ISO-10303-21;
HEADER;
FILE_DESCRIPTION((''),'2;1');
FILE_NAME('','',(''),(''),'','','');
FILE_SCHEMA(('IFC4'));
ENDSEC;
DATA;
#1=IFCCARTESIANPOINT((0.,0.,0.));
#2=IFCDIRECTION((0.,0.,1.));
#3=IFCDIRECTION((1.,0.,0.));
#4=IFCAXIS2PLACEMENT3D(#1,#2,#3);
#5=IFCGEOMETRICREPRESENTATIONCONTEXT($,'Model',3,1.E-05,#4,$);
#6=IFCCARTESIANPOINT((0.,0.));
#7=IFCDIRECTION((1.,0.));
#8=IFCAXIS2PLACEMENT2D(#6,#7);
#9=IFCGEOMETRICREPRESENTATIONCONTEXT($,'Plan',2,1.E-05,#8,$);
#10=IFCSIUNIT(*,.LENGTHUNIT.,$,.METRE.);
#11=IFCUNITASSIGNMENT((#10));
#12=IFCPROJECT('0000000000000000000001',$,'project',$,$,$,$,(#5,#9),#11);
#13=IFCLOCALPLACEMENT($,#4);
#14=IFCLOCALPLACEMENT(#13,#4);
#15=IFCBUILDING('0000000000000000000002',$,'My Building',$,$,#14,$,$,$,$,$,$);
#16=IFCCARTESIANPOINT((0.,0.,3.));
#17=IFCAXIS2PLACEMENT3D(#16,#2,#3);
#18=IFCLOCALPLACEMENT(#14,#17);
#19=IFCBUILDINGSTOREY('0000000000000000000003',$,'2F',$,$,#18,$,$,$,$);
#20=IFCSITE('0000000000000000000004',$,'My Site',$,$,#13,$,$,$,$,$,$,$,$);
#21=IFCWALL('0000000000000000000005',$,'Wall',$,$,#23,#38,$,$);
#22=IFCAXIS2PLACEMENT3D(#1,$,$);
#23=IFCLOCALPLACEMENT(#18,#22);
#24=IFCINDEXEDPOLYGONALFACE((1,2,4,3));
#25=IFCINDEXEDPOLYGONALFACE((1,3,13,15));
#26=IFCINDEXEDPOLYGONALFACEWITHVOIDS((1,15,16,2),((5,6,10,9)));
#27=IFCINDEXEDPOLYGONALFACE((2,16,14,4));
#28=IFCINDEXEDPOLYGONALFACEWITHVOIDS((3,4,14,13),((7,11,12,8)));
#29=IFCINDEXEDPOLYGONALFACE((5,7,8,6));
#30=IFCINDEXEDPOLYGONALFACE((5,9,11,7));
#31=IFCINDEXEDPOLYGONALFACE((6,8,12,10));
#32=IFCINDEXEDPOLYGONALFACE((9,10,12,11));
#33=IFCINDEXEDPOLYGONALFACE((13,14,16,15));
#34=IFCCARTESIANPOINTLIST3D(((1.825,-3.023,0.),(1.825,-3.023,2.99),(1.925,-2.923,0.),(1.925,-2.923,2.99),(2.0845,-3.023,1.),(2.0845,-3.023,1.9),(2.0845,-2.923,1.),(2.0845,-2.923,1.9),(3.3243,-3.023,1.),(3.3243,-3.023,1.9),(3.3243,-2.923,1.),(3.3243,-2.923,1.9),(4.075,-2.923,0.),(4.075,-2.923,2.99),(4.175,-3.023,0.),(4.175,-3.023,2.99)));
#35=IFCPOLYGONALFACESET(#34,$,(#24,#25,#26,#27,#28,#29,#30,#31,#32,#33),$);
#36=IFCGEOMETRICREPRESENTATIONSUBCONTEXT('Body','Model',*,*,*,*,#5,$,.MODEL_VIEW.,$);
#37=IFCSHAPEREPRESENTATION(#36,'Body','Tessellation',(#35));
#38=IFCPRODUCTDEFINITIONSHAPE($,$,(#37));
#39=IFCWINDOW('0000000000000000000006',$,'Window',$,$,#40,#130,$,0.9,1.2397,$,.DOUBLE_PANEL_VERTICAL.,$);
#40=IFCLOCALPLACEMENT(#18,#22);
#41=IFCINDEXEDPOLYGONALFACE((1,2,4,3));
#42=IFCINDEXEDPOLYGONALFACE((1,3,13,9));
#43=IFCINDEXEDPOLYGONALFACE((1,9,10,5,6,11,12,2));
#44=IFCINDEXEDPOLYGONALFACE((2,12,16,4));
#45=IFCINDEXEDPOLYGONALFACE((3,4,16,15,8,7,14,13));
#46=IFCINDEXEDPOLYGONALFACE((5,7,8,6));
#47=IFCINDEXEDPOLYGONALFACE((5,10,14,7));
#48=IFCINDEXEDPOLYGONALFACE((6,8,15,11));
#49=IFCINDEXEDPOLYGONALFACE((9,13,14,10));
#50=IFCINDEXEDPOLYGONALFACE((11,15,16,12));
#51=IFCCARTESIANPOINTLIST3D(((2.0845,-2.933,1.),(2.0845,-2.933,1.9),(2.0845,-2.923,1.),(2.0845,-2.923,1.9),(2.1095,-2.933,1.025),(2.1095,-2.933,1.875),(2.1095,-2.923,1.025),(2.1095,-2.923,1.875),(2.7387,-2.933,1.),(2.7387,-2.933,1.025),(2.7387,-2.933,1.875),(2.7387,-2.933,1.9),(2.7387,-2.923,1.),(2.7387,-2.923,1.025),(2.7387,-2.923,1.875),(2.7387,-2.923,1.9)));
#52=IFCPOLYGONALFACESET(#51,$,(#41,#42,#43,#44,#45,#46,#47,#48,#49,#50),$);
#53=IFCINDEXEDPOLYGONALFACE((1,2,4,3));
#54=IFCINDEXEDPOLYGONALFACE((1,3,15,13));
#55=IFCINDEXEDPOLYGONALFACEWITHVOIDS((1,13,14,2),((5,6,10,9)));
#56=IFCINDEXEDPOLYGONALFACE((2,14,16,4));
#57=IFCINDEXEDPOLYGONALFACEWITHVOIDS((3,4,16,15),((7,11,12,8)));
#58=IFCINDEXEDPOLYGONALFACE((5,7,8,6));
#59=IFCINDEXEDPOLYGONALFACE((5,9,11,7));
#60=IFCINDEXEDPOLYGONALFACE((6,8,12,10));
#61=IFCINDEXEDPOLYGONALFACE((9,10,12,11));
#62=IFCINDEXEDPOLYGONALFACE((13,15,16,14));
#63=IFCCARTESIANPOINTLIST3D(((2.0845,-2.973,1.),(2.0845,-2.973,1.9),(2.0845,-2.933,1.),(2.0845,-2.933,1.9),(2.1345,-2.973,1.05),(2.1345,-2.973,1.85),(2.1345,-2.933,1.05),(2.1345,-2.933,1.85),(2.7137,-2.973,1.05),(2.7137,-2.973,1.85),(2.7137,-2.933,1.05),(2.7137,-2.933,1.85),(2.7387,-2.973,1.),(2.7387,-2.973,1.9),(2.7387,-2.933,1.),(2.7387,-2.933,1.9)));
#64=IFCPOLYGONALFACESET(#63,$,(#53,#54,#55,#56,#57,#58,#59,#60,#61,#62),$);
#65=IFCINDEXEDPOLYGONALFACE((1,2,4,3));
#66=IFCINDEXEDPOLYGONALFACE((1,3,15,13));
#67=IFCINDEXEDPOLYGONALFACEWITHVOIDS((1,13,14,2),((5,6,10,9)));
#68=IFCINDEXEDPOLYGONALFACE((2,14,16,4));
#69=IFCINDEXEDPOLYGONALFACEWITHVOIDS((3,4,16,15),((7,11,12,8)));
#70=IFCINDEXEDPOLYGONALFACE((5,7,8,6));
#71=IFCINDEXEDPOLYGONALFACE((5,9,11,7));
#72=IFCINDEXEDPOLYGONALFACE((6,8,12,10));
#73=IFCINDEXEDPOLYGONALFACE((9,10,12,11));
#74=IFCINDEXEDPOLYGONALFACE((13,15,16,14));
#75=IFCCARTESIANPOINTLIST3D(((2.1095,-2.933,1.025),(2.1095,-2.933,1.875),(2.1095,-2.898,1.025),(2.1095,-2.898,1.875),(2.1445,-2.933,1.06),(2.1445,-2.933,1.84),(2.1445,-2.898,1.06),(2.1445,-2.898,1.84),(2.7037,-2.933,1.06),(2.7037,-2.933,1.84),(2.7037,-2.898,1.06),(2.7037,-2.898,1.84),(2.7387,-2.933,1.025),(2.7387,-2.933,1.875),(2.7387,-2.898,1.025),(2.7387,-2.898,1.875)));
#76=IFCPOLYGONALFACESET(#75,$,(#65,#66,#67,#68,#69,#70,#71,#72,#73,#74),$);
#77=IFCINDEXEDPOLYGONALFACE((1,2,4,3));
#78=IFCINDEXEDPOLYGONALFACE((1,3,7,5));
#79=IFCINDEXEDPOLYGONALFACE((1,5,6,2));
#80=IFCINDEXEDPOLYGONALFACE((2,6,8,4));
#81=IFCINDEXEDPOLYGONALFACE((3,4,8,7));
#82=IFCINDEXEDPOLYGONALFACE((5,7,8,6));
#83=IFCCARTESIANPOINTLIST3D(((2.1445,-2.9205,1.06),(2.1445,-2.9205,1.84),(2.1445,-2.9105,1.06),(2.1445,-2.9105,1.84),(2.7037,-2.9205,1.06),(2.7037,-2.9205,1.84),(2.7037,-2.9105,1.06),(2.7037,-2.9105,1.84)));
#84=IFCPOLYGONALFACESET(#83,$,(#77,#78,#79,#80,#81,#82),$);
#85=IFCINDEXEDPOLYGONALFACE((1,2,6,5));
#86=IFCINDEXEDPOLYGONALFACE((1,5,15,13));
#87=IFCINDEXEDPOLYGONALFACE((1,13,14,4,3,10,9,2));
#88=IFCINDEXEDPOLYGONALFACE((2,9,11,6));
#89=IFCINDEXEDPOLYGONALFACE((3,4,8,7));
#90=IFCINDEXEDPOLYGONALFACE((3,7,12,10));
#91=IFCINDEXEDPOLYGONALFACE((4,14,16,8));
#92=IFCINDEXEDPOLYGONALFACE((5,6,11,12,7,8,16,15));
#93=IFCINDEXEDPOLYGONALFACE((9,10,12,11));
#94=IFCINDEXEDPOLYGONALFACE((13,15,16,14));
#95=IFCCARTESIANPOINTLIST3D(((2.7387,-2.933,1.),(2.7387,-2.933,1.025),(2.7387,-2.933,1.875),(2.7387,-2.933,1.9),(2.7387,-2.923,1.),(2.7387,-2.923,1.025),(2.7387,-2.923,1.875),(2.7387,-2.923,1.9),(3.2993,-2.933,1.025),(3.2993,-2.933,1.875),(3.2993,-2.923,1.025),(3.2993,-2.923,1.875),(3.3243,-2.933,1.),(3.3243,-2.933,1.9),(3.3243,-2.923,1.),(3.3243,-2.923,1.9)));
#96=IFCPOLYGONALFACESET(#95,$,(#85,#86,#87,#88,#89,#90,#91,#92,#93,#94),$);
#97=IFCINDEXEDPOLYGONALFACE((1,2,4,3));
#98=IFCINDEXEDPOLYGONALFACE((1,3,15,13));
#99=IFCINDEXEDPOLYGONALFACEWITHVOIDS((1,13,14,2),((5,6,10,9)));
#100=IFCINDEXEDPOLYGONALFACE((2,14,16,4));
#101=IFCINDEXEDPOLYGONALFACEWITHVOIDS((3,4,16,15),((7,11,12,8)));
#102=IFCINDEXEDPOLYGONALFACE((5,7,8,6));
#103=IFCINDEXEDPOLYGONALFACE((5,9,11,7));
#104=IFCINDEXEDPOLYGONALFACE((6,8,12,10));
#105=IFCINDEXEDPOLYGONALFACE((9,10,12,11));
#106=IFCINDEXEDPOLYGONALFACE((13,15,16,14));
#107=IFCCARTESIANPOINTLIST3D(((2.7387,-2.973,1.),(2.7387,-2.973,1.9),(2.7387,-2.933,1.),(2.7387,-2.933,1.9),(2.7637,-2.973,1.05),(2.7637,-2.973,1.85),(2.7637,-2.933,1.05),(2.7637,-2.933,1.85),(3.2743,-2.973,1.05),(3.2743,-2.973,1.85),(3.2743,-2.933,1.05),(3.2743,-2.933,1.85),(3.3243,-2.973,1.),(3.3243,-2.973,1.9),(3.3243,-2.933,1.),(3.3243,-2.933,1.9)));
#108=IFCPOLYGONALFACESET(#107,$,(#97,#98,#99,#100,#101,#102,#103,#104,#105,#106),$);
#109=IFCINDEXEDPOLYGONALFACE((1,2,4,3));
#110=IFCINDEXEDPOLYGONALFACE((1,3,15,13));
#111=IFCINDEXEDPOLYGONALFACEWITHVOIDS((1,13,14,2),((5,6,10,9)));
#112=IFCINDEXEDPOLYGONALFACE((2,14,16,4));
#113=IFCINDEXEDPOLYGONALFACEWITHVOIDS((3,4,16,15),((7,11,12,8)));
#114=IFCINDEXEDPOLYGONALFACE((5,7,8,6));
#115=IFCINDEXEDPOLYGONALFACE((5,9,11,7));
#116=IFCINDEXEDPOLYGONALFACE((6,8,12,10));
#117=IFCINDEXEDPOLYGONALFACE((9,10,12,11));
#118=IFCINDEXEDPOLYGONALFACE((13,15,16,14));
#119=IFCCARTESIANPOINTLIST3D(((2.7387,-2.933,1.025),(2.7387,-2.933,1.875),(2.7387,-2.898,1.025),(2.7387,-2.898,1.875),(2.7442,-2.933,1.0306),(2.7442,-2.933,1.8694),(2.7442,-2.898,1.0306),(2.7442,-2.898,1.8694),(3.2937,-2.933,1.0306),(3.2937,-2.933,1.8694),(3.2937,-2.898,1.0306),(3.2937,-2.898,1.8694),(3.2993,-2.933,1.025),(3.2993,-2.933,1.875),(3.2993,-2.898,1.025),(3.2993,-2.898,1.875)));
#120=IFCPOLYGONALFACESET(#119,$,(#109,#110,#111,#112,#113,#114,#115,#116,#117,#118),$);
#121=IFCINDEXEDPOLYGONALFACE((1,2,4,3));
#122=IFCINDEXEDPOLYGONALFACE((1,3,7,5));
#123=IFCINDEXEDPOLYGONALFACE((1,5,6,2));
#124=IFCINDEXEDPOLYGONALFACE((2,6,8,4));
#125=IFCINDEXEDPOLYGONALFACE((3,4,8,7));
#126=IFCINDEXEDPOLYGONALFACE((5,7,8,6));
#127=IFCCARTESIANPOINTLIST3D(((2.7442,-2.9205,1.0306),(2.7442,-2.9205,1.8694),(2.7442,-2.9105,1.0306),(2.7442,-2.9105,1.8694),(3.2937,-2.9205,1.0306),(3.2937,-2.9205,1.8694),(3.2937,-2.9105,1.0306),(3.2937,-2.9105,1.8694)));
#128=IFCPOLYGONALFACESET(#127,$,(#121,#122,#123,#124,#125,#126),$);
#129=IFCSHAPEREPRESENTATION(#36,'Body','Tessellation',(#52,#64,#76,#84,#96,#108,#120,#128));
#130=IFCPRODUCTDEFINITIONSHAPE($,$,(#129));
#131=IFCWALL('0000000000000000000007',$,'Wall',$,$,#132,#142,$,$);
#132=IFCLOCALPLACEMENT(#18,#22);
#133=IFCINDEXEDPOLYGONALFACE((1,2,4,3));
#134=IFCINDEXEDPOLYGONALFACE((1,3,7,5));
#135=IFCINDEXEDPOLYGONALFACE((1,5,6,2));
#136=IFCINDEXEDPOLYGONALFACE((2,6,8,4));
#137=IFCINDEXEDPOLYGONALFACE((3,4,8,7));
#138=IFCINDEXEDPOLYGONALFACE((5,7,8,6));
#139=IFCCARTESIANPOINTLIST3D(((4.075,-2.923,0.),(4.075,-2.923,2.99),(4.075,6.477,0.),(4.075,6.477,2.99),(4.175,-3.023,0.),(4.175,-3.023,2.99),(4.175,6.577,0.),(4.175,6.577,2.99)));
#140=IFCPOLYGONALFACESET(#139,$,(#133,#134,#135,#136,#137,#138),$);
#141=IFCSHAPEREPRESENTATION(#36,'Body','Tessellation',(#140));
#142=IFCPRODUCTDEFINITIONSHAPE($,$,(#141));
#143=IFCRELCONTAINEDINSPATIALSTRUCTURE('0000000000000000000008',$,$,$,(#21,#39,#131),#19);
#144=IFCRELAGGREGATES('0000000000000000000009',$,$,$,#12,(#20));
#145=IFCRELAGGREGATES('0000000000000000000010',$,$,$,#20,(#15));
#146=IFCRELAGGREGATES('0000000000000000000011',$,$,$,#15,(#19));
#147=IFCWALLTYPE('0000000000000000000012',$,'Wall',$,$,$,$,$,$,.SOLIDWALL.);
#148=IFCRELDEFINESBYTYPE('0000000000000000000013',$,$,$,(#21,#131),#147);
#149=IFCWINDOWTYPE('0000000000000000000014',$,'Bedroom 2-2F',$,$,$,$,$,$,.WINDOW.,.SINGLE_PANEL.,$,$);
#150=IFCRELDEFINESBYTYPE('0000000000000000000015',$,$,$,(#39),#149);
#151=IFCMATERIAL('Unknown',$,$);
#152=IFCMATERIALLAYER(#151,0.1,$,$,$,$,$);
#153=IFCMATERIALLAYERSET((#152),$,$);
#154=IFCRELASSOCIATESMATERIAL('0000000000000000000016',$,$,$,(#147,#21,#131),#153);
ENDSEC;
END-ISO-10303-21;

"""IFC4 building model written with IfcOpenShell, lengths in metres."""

from ifc_helpers import new_model, entity, si_unit, frame, origin_with_axes, origin_2d_with_axis, place, context, subcontext, project, spatial, line, indexed_curve, outline, extrude, shape, source, transform, mapped, material, layer, layer_set, layer_usage, type_object, type_shapes, element, fill, save


model = new_model("IFC4")

# Units and contexts
model_context = context("Model", 3, precision=1e-05, world=origin_with_axes())
plan_context = context("Plan", 2, precision=1e-05, world=origin_2d_with_axis())
body_context_1 = subcontext(model_context, "Body", "Model", "MODEL_VIEW")
body_context_2 = subcontext(plan_context, "Body", "Plan", "PLAN_VIEW")
ifc_project = project(units=[si_unit("LENGTHUNIT", "METRE")], contexts=[model_context, plan_context])

# Site, building, storey
site_placement = place(None, origin_with_axes())
site = spatial("IfcSite", under=ifc_project, at=site_placement, Name="My Site")
building_placement = place(site_placement, origin_with_axes())
building = spatial("IfcBuilding", under=site, at=building_placement, Name="My Building")
storey_placement = place(building_placement, frame((0.0, 0.0, 3.0), z_axis=(0.0, 0.0, 1.0), x_axis=(1.0, 0.0, 0.0)))
storey = spatial("IfcBuildingStorey", under=building, at=storey_placement, Name="2F")

# Shared definitions
ifc_material = material(Name="Unknown")

# Shared definitions
ifc_layer_1 = layer(ifc_material, 0.1)
ifc_layer_set_1 = layer_set([ifc_layer_1])
wall_type = type_object("IfcWallType", Name="Wall", PredefinedType="SOLIDWALL", material=ifc_layer_set_1)

# Wall, opening, window
ifc_layer_usage_1 = layer_usage(ifc_layer_set_1, "AXIS2", "POSITIVE", 0.0)
wall_1_placement = place(storey_placement, frame((1.825, -3.023, 0.0), z_axis=(0.0, 0.0, 1.0), x_axis=(1.0, 0.0, 0.0)))
wall_1 = element("IfcWall", 1, at=wall_1_placement, inside=storey, type_object=wall_type, material=ifc_layer_usage_1, Name="Wall", context=body_context_1, shape_type="SweptSolid", body=[
    extrude(outline(indexed_curve([(0.0, 0.0), (0.1, 0.1), (2.25, 0.1), (2.35, 0.0)], segments=[line(1, 2, 3, 4, 1)])), origin_with_axes(), (0.0, 0.0, 1.0), 2.99),
])
shared_shape_1 = source(origin_with_axes(), body_context_1, "Body", "SweptSolid", [
    extrude(outline(indexed_curve([(0.0, 0.0), (1.2397, 0.0), (1.2397, 0.9), (0.0, 0.9)], segments=[line(1, 2, 3, 4, 1)])), frame((0.0, -0.6, 0.0), z_axis=(0.0, -1.0, 0.0), x_axis=(1.0, 0.0, 0.0)), (0.0, 0.0, -1.0), 1.2),
])
opening_1_placement = place(wall_1_placement, frame((0.2595, 0.0, 1.0), z_axis=(0.0, 0.0, 1.0), x_axis=(1.0, 0.0, 0.0)))
opening_1 = element("IfcOpeningElement", 2, at=opening_1_placement, cuts=wall_1, PredefinedType="OPENING", context=body_context_1, shape_type="MappedRepresentation", body=[
    mapped(shared_shape_1, transform((0.0, 0.0, 0.0), x_axis=(1.0, 0.0, 0.0), y_axis=(0.0, 1.0, 0.0), z_axis=(0.0, 0.0, 1.0), scale=1.0)),
])
window_type_1 = type_object("IfcWindowType", Name="Bedroom 2-2F", PartitioningType="SINGLE_PANEL", PredefinedType="WINDOW")
shared_shape_2 = source(origin_with_axes(), body_context_1, "Body", "SweptSolid", [
    extrude(outline(indexed_curve([(0.6541, 0.0), (0.0, 0.0), (0.0, 0.9), (0.6541, 0.9), (0.6541, 0.875), (0.025, 0.875), (0.025, 0.025), (0.6541, 0.025)], segments=[line(1, 2, 3, 4, 5, 6, 7, 8, 1)])), frame((0.0, 0.09, 0.0), z_axis=(0.0, -1.0, 0.0), x_axis=(1.0, 0.0, 0.0)), (0.0, 0.0, -1.0), 0.01),
    extrude(outline(indexed_curve([(0.0, 0.0), (0.6541, 0.0), (0.6541, 0.9), (0.0, 0.9)], segments=[line(1, 2, 3, 4, 1)]), holes=[indexed_curve([(0.05, 0.05), (0.6291, 0.05), (0.6291, 0.85), (0.05, 0.85)], segments=[line(1, 2, 3, 4, 1)])]), frame((0.0, 0.05, 0.0), z_axis=(0.0, -1.0, 0.0), x_axis=(1.0, 0.0, 0.0)), (0.0, 0.0, -1.0), 0.04),
    extrude(outline(indexed_curve([(0.0, 0.0), (0.6291, 0.0), (0.6291, 0.85), (0.0, 0.85)], segments=[line(1, 2, 3, 4, 1)]), holes=[indexed_curve([(0.035, 0.035), (0.5941, 0.035), (0.5941, 0.815), (0.035, 0.815)], segments=[line(1, 2, 3, 4, 1)])]), frame((0.025, 0.09, 0.025), z_axis=(0.0, -1.0, 0.0), x_axis=(1.0, 0.0, 0.0)), (0.0, 0.0, -1.0), 0.035),
    extrude(outline(indexed_curve([(0.035, 0.035), (0.5941, 0.035), (0.5941, 0.815), (0.035, 0.815)], segments=[line(1, 2, 3, 4, 1)])), frame((0.025, 0.1025, 0.025), z_axis=(0.0, -1.0, 0.0), x_axis=(1.0, 0.0, 0.0)), (0.0, 0.0, -1.0), 0.01),
    extrude(outline(indexed_curve([(0.0, 0.9), (0.5856, 0.9), (0.5856, 0.0), (0.0, 0.0), (0.0, 0.025), (0.5606, 0.025), (0.5606, 0.875), (0.0, 0.875)], segments=[line(1, 2, 3, 4, 5, 6, 7, 8, 1)])), frame((0.6541, 0.09, 0.0), z_axis=(0.0, -1.0, 0.0), x_axis=(1.0, 0.0, 0.0)), (0.0, 0.0, -1.0), 0.01),
    extrude(outline(indexed_curve([(0.0, 0.0), (0.5856, 0.0), (0.5856, 0.9), (0.0, 0.9)], segments=[line(1, 2, 3, 4, 1)]), holes=[indexed_curve([(0.025, 0.05), (0.5356, 0.05), (0.5356, 0.85), (0.025, 0.85)], segments=[line(1, 2, 3, 4, 1)])]), frame((0.6541, 0.05, 0.0), z_axis=(0.0, -1.0, 0.0), x_axis=(1.0, 0.0, 0.0)), (0.0, 0.0, -1.0), 0.04),
    extrude(outline(indexed_curve([(0.0, 0.0), (0.5606, 0.0), (0.5606, 0.85), (0.0, 0.85)], segments=[line(1, 2, 3, 4, 1)]), holes=[indexed_curve([(0.0056, 0.0056), (0.555, 0.0056), (0.555, 0.8444), (0.0056, 0.8444)], segments=[line(1, 2, 3, 4, 1)])]), frame((0.6541, 0.09, 0.025), z_axis=(0.0, -1.0, 0.0), x_axis=(1.0, 0.0, 0.0)), (0.0, 0.0, -1.0), 0.035),
    extrude(outline(indexed_curve([(0.0056, 0.0056), (0.555, 0.0056), (0.555, 0.8444), (0.0056, 0.8444)], segments=[line(1, 2, 3, 4, 1)])), frame((0.6541, 0.1025, 0.025), z_axis=(0.0, -1.0, 0.0), x_axis=(1.0, 0.0, 0.0)), (0.0, 0.0, -1.0), 0.01),
])
shared_shape_3 = source(origin_with_axes(), body_context_2, "Body", "Curve2D", [
    entity("IfcIndexedPolyCurve", entity("IfcCartesianPointList2D", [[0.05, 0.05], [0.6291, 0.05]])),
    entity("IfcIndexedPolyCurve", entity("IfcCartesianPointList2D", [[0.0, 0.1], [0.025, 0.1], [0.025, 0.09], [0.05, 0.09], [0.05, 0.05], [0.0, 0.05]]), [entity("IfcLineIndex", [1, 2, 3, 4, 5, 6, 1])]),
    entity("IfcIndexedPolyCurve", entity("IfcCartesianPointList2D", [[0.6541, 0.1], [0.6541, 0.1], [0.6541, 0.09], [0.6291, 0.09], [0.6291, 0.05], [0.6541, 0.05]])),
    entity("IfcIndexedPolyCurve", entity("IfcCartesianPointList2D", [[0.025, 0.09], [0.06, 0.09], [0.06, 0.125], [0.025, 0.125]]), [entity("IfcLineIndex", [1, 2, 3, 4, 1])]),
    entity("IfcIndexedPolyCurve", entity("IfcCartesianPointList2D", [[0.6541, 0.09], [0.6191, 0.09], [0.6191, 0.125], [0.6541, 0.125]]), [entity("IfcLineIndex", [1, 2, 3, 4, 1])]),
    entity("IfcIndexedPolyCurve", entity("IfcCartesianPointList2D", [[0.06, 0.09], [0.6191, 0.09]])),
    entity("IfcIndexedPolyCurve", entity("IfcCartesianPointList2D", [[0.06, 0.125], [0.6191, 0.125]])),
    entity("IfcIndexedPolyCurve", entity("IfcCartesianPointList2D", [[0.06, 0.1075], [0.6191, 0.1075]])),
    entity("IfcIndexedPolyCurve", entity("IfcCartesianPointList2D", [[0.6791, 0.05], [1.1897, 0.05]])),
    entity("IfcIndexedPolyCurve", entity("IfcCartesianPointList2D", [[0.6541, 0.1], [0.6541, 0.1], [0.6541, 0.09], [0.6791, 0.09], [0.6791, 0.05], [0.6541, 0.05]])),
    entity("IfcIndexedPolyCurve", entity("IfcCartesianPointList2D", [[1.2397, 0.1], [1.2147, 0.1], [1.2147, 0.09], [1.1897, 0.09], [1.1897, 0.05], [1.2397, 0.05]]), [entity("IfcLineIndex", [1, 2, 3, 4, 5, 6, 1])]),
    entity("IfcIndexedPolyCurve", entity("IfcCartesianPointList2D", [[0.6541, 0.09], [0.6597, 0.09], [0.6597, 0.125], [0.6541, 0.125]]), [entity("IfcLineIndex", [1, 2, 3, 4, 1])]),
    entity("IfcIndexedPolyCurve", entity("IfcCartesianPointList2D", [[1.2147, 0.09], [1.2092, 0.09], [1.2092, 0.125], [1.2147, 0.125]]), [entity("IfcLineIndex", [1, 2, 3, 4, 1])]),
    entity("IfcIndexedPolyCurve", entity("IfcCartesianPointList2D", [[0.6597, 0.09], [1.2092, 0.09]])),
    entity("IfcIndexedPolyCurve", entity("IfcCartesianPointList2D", [[0.6597, 0.125], [1.2092, 0.125]])),
    entity("IfcIndexedPolyCurve", entity("IfcCartesianPointList2D", [[0.6597, 0.1075], [1.2092, 0.1075]])),
])
type_shapes(window_type_1, [shared_shape_2, shared_shape_3])
window_1_placement = place(opening_1_placement, frame((0.0, 0.0, 0.0), z_axis=(0.0, 0.0, 1.0), x_axis=(1.0, 0.0, 0.0)))
window_1 = element("IfcWindow", 3, at=window_1_placement, inside=storey, type_object=window_type_1, Name="Window", OverallHeight=0.9, OverallWidth=1.2397, PartitioningType="DOUBLE_PANEL_VERTICAL", shapes=[
    shape(body_context_1, "Body", "MappedRepresentation", [mapped(shared_shape_2, transform((0.0, 0.0, 0.0), x_axis=(1.0, 0.0, 0.0), y_axis=(0.0, 1.0, 0.0), z_axis=(0.0, 0.0, 1.0), scale=1.0))]),
    shape(body_context_2, "Body", "MappedRepresentation", [mapped(shared_shape_3, transform((0.0, 0.0, 0.0), x_axis=(1.0, 0.0, 0.0), y_axis=(0.0, 1.0, 0.0), z_axis=(0.0, 0.0, 1.0), scale=1.0))]),
])
fill(opening_1, window_1)

# Wall
ifc_layer_usage_2 = layer_usage(ifc_layer_set_1, "AXIS2", "POSITIVE", 0.0)
wall_2_placement = place(storey_placement, frame((4.175, -3.023, 0.0), z_axis=(0.0, 0.0, 1.0), x_axis=(0.0, 1.0, 0.0)))
element("IfcWall", 4, at=wall_2_placement, inside=storey, type_object=wall_type, material=ifc_layer_usage_2, Name="Wall", context=body_context_1, shape_type="SweptSolid", body=[
    extrude(outline(indexed_curve([(0.0, 0.0), (0.1, 0.1), (9.5, 0.1), (9.6, 0.0)], segments=[line(1, 2, 3, 4, 1)])), origin_with_axes(), (0.0, 0.0, 1.0), 2.99),
])

save(model, "model.ifc")
